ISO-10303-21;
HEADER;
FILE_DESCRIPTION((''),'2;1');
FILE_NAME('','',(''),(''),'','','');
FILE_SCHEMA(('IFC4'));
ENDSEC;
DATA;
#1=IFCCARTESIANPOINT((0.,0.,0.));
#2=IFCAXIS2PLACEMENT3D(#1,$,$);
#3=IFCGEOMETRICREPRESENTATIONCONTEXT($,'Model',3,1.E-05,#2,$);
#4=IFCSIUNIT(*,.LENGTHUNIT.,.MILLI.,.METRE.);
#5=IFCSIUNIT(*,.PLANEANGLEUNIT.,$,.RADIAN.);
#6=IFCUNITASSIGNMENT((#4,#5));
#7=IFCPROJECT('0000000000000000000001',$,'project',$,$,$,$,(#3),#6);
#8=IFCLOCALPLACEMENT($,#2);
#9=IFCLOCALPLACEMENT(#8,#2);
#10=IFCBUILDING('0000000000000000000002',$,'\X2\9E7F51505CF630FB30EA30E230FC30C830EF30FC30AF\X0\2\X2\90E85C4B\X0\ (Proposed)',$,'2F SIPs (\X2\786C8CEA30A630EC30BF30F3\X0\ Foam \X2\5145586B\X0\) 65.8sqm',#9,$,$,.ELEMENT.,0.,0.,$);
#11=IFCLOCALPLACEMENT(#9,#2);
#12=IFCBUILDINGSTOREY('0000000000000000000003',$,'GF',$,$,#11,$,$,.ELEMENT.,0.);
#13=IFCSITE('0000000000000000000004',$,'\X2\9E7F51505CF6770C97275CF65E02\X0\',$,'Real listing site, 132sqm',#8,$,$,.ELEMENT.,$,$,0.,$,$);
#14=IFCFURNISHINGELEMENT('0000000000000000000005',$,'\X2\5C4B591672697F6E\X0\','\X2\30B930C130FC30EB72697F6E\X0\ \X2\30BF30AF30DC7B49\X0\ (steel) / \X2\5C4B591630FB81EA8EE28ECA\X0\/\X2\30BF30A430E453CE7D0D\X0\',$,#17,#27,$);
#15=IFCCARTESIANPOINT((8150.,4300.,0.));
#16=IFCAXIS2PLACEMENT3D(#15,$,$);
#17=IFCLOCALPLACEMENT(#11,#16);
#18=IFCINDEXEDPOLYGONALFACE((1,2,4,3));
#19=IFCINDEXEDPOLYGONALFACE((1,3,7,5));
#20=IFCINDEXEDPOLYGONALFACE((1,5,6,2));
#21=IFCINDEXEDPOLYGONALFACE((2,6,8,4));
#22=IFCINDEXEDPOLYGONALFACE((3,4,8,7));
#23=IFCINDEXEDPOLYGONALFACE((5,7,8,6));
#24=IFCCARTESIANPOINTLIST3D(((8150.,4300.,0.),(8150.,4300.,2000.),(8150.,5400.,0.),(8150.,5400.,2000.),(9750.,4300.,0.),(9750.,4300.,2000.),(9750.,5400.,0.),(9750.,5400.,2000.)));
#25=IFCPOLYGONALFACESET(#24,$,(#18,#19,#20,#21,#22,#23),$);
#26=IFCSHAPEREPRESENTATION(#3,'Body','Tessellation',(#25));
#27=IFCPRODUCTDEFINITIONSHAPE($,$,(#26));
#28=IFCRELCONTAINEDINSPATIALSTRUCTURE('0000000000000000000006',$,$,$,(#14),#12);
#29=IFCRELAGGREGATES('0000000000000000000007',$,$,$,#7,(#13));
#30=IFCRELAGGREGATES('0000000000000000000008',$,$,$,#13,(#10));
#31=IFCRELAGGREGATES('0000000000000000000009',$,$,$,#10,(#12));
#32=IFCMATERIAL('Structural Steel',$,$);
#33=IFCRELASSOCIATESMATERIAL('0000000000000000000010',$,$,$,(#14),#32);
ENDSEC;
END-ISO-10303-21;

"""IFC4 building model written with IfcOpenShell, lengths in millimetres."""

from ifc_helpers import new_model, si_unit, frame, frame_2d, origin, place, context, project, spatial, rectangle, extrude, material, element, save


model = new_model("IFC4")

# Units and contexts
model_context = context("Model", 3, precision=1e-05, world=origin())
ifc_project = project(units=[si_unit("LENGTHUNIT", "METRE", prefix="MILLI"), si_unit("PLANEANGLEUNIT", "RADIAN")], contexts=[model_context])

# Site, building, storey
site_placement = place(None, origin())
site = spatial("IfcSite", under=ifc_project, at=site_placement, Name="鹿児島県霧島市", ObjectType="Real listing site, 132sqm", CompositionType="ELEMENT", RefElevation=0.0)
building_placement = place(site_placement, origin())
building = spatial("IfcBuilding", under=site, at=building_placement, Name="鹿児島・リモートワーク2部屋 (Proposed)", ObjectType="2F SIPs (硬質ウレタン Foam 充填) 65.8sqm", CompositionType="ELEMENT", ElevationOfRefHeight=0.0, ElevationOfTerrain=0.0)
storey_placement = place(building_placement, origin())
storey = spatial("IfcBuildingStorey", under=building, at=storey_placement, Name="GF", CompositionType="ELEMENT", Elevation=0.0)

# Shared definitions
ifc_material_1 = material(Name="Structural Steel")

# Furnishing element
furnishing_1_placement = place(storey_placement, frame((8150.0, 4300.0, 0.0)))
element("IfcFurnishingElement", 1, at=furnishing_1_placement, inside=storey, material=ifc_material_1, Name="屋外物置", Description="スチール物置 タクボ等 (steel) / 屋外・自転車/タイヤ収納", context=model_context, shape_type="SweptSolid", body=[
    extrude(rectangle(XDim=1600.0, YDim=1100.0, at=frame_2d((800.0, 550.0))), frame((8150.0, 4300.0, 0.0)), (0.0, 0.0, 1.0), 2000.0),
])

save(model, "model.ifc")
